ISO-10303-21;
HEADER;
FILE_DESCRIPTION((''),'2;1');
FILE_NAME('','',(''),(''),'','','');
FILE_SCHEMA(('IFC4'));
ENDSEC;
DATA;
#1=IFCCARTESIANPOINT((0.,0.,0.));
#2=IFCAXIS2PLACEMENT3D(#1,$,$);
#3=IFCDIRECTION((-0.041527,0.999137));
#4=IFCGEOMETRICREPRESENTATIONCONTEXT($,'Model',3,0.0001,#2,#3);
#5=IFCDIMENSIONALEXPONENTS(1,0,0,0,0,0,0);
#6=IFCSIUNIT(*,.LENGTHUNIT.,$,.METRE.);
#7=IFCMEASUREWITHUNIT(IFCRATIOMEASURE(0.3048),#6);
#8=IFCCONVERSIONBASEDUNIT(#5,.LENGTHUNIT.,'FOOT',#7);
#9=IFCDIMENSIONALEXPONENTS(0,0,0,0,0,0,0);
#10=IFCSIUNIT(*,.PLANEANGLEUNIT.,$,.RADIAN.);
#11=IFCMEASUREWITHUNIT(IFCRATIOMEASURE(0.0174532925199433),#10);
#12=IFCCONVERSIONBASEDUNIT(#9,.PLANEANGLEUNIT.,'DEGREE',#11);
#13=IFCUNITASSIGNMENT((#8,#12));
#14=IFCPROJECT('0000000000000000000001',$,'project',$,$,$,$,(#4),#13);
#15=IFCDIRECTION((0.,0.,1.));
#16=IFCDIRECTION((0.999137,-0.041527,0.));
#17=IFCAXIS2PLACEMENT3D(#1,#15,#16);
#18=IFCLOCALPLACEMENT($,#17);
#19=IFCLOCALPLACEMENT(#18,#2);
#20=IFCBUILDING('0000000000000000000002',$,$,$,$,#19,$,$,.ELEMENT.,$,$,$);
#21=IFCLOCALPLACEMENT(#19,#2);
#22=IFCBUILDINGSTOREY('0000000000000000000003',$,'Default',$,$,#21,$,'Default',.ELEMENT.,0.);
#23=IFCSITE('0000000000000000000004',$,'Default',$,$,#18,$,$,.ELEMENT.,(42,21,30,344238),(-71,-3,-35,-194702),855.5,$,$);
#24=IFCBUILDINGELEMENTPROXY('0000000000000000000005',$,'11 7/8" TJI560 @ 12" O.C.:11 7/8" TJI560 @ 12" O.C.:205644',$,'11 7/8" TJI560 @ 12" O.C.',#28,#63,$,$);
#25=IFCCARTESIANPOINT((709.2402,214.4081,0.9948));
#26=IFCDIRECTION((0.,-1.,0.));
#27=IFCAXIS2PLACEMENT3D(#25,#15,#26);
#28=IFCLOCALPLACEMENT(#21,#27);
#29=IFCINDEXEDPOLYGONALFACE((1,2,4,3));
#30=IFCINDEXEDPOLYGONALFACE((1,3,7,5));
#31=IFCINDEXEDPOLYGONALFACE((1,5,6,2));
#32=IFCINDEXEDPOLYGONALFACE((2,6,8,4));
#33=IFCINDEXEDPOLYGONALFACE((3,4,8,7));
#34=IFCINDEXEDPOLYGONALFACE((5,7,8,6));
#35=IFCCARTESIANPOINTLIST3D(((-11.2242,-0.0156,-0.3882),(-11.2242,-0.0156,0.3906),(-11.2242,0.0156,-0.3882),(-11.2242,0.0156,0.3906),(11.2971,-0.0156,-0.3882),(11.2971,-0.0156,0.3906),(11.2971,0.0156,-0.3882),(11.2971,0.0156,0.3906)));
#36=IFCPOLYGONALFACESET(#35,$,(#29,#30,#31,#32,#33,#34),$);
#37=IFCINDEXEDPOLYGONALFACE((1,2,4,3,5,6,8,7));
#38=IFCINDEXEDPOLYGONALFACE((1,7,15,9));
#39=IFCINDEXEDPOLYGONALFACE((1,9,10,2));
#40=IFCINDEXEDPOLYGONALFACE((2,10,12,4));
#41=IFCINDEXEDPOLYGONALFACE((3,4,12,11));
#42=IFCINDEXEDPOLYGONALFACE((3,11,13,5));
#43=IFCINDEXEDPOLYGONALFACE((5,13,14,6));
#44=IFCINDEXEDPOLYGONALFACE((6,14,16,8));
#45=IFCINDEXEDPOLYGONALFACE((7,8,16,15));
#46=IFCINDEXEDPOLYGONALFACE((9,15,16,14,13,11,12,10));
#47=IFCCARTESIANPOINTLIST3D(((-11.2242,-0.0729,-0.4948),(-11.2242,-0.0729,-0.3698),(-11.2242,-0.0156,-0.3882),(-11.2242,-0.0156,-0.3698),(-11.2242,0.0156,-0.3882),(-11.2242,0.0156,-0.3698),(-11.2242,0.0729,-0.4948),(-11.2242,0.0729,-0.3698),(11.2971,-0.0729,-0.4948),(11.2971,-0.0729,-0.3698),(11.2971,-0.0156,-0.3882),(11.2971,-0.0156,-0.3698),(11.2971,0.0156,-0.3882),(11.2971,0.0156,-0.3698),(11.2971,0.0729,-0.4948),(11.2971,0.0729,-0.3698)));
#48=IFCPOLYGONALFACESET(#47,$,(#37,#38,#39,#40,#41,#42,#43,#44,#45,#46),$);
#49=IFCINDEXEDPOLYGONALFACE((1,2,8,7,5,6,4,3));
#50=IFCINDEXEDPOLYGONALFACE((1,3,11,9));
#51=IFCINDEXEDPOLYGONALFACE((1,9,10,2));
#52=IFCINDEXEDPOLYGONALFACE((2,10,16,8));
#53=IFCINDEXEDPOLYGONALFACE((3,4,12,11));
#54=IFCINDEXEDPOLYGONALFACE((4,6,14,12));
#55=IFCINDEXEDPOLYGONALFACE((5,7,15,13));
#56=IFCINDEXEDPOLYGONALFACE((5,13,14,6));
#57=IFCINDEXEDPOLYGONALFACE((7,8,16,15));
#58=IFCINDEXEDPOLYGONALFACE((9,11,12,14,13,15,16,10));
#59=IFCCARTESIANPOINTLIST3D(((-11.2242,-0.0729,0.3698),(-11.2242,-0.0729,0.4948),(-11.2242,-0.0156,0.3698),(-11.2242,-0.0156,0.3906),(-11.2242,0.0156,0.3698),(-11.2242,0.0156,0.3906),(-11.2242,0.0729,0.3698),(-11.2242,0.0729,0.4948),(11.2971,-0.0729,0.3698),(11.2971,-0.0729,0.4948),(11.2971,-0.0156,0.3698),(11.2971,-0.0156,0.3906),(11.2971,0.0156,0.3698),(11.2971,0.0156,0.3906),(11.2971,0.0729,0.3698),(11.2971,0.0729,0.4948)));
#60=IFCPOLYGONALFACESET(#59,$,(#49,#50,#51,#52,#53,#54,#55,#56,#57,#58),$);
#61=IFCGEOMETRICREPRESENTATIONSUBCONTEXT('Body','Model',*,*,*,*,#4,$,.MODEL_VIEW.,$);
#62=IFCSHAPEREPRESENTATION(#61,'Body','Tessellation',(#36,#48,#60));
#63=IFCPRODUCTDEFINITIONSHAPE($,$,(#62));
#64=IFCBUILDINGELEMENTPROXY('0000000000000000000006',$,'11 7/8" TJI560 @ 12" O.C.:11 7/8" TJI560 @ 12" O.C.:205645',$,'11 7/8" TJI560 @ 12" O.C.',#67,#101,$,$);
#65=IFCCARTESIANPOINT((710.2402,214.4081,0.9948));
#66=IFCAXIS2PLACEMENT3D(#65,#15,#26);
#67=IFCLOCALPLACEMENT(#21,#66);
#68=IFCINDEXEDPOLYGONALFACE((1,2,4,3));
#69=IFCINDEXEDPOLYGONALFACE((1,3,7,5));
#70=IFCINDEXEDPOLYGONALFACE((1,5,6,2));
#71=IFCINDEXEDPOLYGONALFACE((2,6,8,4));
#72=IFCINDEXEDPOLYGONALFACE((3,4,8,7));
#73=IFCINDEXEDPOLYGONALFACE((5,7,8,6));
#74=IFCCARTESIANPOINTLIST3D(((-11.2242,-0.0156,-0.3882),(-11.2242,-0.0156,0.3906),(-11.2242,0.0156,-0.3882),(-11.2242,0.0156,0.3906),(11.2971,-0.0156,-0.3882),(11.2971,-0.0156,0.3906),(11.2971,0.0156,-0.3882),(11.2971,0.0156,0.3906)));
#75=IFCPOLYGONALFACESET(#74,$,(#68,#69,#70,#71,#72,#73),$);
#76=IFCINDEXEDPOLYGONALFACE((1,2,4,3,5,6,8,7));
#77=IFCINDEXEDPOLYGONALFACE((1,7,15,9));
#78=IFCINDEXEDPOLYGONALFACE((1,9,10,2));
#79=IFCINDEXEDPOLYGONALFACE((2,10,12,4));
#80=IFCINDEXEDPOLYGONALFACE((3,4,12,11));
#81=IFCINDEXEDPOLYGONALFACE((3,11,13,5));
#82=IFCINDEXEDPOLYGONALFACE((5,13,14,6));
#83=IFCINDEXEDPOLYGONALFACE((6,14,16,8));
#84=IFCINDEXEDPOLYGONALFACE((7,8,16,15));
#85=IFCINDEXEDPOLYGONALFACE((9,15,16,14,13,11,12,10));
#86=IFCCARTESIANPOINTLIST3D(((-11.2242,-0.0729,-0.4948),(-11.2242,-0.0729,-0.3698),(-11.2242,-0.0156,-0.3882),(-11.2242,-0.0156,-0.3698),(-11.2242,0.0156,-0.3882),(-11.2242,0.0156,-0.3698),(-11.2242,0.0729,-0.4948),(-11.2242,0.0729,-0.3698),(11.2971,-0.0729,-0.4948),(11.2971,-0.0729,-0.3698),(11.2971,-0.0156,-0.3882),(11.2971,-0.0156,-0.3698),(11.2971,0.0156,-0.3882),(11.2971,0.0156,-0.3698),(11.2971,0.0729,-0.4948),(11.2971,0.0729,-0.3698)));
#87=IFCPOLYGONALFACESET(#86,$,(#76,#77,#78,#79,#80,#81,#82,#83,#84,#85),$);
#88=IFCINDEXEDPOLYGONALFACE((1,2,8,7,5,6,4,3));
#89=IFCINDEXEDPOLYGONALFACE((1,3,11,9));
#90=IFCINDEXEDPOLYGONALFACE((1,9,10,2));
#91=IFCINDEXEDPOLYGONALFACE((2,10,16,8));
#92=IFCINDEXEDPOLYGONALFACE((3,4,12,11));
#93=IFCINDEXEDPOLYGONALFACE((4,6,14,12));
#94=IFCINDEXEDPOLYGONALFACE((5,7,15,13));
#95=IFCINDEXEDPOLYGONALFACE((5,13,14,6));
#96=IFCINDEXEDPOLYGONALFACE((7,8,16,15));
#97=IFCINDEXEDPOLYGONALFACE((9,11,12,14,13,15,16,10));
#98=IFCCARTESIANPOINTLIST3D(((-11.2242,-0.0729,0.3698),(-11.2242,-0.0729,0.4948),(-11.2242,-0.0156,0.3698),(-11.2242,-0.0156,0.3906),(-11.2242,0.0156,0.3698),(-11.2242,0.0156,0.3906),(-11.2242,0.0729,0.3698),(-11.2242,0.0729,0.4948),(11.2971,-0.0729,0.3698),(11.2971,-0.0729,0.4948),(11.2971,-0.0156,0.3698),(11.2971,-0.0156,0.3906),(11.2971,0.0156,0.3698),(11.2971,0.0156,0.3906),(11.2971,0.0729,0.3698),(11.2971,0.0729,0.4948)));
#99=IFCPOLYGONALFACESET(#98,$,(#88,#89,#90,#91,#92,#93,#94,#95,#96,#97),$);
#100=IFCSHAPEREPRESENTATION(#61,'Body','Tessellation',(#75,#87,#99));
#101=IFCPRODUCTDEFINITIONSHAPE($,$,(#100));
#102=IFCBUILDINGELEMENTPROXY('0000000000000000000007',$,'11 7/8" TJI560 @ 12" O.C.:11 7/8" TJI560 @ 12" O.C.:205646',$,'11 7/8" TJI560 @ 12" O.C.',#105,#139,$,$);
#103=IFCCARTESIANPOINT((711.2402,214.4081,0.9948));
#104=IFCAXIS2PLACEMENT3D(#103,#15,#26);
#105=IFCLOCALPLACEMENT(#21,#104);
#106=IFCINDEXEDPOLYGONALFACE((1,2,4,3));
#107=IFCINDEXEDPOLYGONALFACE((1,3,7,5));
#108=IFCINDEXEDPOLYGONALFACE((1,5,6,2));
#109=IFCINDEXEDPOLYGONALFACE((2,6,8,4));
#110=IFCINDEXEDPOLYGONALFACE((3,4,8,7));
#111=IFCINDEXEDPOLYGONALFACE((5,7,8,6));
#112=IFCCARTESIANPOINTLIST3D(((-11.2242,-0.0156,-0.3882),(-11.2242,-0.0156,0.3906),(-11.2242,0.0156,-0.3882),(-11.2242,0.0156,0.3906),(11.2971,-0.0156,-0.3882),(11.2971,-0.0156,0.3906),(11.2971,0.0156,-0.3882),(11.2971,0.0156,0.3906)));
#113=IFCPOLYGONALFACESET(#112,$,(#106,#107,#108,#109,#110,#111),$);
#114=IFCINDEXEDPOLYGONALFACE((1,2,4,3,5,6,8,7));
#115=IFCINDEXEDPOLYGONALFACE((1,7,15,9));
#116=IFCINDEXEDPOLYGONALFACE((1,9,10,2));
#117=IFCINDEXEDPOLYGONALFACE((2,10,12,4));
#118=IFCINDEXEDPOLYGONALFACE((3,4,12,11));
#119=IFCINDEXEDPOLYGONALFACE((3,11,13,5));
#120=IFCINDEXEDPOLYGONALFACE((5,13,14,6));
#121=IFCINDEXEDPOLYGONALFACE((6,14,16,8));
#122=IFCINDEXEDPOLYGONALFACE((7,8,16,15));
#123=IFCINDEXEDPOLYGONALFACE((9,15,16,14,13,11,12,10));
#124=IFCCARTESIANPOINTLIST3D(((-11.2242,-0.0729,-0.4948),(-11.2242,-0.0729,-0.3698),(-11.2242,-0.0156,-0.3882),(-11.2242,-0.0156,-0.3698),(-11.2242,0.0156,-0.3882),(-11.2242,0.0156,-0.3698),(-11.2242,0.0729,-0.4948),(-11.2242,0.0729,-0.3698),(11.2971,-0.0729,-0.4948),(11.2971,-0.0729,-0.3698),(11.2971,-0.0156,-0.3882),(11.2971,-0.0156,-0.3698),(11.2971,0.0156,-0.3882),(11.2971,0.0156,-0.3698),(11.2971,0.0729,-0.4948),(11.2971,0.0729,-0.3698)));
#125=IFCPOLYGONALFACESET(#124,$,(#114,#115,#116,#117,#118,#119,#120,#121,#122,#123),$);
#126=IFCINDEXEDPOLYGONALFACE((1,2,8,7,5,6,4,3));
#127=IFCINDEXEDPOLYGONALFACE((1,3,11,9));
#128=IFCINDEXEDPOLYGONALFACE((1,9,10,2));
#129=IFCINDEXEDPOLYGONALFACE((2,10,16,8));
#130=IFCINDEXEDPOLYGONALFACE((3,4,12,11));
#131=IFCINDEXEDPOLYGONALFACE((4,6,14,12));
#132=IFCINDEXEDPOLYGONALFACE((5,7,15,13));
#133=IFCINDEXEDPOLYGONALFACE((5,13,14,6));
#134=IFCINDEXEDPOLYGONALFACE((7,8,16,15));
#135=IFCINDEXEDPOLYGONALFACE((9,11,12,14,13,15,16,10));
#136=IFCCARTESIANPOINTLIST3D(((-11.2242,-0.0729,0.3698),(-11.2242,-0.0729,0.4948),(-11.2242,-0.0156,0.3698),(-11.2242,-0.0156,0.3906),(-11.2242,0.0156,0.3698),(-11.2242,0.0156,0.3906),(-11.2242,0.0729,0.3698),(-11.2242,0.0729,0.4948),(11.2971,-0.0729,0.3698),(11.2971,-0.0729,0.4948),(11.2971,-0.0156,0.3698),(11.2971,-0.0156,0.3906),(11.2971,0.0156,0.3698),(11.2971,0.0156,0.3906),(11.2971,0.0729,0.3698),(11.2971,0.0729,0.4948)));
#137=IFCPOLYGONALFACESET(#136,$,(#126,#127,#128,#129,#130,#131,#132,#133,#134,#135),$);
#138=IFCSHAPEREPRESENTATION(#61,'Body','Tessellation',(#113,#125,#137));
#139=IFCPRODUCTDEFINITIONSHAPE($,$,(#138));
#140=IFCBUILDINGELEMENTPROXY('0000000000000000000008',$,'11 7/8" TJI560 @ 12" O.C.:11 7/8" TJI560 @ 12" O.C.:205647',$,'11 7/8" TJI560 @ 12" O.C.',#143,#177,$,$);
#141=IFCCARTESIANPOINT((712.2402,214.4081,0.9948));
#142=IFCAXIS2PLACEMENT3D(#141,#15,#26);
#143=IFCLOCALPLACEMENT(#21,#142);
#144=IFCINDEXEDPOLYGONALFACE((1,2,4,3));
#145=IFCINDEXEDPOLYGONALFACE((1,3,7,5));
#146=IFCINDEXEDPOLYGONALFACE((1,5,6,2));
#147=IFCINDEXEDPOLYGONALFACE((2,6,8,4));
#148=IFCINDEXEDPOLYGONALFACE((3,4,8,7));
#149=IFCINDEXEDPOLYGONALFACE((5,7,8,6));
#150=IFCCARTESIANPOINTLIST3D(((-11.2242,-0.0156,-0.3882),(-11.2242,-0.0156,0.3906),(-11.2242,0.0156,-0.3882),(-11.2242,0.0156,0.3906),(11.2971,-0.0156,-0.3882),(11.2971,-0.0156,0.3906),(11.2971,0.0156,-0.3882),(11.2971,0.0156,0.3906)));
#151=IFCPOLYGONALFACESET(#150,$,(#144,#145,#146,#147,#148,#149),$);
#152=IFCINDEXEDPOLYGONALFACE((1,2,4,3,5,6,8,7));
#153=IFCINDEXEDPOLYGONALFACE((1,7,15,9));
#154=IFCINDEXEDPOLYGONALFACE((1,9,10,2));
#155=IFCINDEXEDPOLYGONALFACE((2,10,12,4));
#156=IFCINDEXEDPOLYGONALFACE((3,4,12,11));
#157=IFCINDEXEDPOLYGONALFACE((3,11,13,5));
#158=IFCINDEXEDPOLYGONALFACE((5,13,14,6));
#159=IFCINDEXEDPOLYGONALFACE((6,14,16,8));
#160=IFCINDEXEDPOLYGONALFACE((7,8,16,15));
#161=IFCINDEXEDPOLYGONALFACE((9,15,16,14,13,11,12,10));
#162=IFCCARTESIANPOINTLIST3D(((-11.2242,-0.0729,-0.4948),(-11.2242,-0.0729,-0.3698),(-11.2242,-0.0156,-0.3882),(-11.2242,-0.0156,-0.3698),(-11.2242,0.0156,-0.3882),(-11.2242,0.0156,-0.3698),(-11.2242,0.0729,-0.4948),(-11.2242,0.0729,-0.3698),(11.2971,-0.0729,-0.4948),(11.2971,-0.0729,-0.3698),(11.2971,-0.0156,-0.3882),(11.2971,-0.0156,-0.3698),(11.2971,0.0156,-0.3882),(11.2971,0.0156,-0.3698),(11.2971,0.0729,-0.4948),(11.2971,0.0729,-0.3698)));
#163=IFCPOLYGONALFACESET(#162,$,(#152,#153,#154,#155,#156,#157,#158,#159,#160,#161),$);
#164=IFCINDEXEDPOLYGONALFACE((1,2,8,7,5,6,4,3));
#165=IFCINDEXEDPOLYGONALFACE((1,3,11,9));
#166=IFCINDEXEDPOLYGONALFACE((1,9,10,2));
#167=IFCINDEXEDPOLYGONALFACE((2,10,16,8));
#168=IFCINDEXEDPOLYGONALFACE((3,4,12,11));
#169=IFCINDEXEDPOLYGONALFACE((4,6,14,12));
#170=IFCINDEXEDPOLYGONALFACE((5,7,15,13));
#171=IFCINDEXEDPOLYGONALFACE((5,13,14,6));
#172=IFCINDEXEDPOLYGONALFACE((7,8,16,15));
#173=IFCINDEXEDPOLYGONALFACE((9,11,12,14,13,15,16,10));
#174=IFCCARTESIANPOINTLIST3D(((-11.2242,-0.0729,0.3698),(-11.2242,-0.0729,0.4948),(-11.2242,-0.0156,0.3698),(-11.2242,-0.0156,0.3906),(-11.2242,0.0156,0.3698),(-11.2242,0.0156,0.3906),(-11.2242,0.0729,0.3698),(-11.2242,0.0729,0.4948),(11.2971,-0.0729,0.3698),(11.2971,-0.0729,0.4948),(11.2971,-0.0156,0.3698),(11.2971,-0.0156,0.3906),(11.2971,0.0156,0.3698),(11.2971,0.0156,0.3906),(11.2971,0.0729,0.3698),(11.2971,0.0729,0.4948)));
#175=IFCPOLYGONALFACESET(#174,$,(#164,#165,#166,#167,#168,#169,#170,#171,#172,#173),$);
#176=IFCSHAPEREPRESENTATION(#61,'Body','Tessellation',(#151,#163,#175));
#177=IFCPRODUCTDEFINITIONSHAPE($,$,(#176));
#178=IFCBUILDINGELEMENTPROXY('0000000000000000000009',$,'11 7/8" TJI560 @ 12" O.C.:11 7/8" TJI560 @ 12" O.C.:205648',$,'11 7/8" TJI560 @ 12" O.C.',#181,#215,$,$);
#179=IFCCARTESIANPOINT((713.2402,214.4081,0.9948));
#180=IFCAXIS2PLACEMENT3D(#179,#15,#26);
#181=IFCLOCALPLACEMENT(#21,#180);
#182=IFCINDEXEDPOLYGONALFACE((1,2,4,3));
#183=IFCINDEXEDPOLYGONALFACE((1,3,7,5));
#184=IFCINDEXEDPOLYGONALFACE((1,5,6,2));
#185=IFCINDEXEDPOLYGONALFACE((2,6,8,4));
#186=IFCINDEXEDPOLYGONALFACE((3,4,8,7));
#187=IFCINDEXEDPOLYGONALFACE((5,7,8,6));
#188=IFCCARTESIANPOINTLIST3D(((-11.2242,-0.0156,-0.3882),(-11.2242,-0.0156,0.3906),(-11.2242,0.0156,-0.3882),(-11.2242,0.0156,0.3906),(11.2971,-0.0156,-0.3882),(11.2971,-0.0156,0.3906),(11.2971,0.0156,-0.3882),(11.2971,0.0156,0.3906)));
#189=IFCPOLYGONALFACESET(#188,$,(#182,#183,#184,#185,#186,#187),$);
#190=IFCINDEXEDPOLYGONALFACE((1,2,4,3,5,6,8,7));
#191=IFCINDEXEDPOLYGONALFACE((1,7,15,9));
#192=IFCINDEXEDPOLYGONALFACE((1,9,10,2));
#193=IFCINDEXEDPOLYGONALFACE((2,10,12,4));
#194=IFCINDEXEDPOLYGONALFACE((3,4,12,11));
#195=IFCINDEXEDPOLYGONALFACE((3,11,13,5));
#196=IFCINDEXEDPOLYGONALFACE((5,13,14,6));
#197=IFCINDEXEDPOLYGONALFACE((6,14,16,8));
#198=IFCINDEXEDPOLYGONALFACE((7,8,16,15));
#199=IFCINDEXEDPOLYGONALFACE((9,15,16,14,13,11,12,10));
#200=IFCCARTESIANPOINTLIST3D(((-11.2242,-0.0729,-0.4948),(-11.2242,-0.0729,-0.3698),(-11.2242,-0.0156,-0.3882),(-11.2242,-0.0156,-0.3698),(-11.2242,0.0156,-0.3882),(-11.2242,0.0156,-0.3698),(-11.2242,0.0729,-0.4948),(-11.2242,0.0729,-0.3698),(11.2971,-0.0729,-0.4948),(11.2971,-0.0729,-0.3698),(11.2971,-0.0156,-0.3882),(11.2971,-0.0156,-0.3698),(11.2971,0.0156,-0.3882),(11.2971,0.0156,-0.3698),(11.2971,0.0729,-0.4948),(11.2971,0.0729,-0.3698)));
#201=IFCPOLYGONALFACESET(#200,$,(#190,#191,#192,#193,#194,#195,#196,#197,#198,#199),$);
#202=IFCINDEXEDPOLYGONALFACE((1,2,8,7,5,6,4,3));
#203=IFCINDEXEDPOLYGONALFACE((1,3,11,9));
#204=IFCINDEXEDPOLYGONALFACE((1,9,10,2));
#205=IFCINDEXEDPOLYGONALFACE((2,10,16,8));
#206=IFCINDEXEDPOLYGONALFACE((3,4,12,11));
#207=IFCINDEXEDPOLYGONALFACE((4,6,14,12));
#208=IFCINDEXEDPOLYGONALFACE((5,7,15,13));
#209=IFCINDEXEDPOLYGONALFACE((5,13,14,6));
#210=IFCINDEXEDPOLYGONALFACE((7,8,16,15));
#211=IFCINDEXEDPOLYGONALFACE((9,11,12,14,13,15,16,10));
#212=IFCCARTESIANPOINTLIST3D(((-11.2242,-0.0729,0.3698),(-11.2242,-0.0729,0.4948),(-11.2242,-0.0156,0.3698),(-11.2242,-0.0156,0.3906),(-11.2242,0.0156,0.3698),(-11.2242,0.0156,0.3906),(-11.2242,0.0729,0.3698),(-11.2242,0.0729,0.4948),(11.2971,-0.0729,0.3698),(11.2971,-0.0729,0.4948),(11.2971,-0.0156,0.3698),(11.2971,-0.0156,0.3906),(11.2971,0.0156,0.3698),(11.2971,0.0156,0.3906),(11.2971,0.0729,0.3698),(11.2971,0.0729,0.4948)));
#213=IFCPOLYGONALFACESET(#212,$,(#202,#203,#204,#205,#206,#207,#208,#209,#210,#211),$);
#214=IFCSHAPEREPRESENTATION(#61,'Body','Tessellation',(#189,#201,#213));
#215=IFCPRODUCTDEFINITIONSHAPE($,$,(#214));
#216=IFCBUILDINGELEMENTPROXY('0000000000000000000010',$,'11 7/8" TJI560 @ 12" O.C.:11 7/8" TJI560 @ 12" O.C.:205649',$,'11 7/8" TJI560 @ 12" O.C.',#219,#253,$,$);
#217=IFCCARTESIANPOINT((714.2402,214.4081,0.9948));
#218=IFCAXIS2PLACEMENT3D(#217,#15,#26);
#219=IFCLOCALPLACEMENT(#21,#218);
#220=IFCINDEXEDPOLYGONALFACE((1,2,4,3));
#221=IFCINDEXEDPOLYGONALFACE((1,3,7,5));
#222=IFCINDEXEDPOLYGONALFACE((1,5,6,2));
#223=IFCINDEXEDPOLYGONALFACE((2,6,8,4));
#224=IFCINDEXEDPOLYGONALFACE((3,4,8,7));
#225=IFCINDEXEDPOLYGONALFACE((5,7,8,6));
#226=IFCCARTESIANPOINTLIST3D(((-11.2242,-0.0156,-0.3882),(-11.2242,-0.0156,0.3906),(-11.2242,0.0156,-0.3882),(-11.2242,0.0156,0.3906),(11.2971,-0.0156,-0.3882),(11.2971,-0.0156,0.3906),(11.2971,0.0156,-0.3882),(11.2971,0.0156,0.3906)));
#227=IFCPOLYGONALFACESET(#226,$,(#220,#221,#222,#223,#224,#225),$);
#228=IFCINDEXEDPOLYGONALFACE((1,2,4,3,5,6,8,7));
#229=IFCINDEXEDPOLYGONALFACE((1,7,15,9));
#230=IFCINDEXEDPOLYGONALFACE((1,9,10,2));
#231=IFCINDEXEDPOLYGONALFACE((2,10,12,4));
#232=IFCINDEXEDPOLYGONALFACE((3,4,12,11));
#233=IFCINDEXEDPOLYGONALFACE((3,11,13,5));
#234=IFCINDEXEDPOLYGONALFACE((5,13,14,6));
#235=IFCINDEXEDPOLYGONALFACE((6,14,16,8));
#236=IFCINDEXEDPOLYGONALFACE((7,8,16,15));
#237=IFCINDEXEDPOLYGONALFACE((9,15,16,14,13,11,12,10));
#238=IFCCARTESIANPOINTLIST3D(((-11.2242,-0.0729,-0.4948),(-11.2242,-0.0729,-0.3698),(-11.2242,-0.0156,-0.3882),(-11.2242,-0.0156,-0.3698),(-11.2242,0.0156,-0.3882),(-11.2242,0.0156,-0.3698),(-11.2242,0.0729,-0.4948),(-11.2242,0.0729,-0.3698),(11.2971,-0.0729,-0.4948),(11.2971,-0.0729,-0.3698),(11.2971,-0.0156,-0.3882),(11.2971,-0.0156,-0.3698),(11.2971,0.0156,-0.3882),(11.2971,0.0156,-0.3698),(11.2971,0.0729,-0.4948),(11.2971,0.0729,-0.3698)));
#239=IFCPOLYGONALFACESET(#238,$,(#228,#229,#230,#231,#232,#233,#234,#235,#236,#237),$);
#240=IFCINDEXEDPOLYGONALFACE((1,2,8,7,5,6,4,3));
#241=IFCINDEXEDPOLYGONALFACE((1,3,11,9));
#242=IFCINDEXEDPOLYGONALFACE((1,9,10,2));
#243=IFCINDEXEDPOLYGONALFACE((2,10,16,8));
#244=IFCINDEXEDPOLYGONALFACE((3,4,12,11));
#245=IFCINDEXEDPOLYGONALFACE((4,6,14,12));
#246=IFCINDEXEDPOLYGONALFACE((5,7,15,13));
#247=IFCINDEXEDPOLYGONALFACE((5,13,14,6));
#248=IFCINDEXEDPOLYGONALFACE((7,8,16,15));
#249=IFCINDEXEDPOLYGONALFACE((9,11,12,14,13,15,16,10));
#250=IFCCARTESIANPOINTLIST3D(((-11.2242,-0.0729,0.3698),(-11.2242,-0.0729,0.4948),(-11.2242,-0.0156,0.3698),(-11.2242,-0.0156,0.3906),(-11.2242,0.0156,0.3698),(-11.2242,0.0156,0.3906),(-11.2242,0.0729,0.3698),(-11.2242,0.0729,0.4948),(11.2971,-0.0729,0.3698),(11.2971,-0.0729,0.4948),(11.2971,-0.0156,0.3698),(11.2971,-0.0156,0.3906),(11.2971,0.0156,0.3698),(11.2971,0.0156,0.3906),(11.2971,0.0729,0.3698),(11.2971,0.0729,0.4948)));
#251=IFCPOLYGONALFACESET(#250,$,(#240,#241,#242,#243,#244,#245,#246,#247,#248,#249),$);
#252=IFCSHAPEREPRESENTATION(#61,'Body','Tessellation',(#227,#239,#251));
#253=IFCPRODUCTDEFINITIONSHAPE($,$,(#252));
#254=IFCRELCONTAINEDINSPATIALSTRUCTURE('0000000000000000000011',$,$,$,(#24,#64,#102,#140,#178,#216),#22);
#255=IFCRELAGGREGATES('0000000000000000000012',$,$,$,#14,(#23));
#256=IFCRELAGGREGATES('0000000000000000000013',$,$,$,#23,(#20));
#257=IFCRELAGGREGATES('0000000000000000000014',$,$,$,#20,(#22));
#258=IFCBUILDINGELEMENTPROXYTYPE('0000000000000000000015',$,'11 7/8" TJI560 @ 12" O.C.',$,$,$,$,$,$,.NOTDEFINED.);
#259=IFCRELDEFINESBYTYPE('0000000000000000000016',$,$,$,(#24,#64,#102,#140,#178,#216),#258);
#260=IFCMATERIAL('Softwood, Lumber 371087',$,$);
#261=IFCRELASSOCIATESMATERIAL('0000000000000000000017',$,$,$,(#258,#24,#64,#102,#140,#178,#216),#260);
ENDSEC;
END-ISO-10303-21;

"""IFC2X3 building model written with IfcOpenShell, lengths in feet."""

from ifc_helpers import new_model, entity, si_unit, converted_unit, direction, frame, origin, origin_2d_with_axis, place, context, subcontext, project, spatial, polyline, rectangle, outline, extrude, source, transform, mapped, material, type_object, type_shapes, element, save


model = new_model("IFC2X3")

# Units and contexts
model_context = context("Model", 3, precision=0.0001, world=origin(), true_north=direction((-0.041527, 0.999137)))
body_context = subcontext(model_context, "Body", "Model", "MODEL_VIEW")
ifc_project = project(units=[converted_unit("LENGTHUNIT", "FOOT", entity("IfcRatioMeasure", 0.3048), si_unit("LENGTHUNIT", "METRE"), dimensions=[1, 0, 0, 0, 0, 0, 0]), converted_unit("PLANEANGLEUNIT", "DEGREE", entity("IfcRatioMeasure", 0.0174532925199433), si_unit("PLANEANGLEUNIT", "RADIAN"), dimensions=[0, 0, 0, 0, 0, 0, 0])], contexts=[model_context])

# Site, building, storey
site_placement = place(None, frame((0.0, 0.0, 0.0), z_axis=(0.0, 0.0, 1.0), x_axis=(0.999137, -0.041527, 0.0)))
site = spatial("IfcSite", under=ifc_project, at=site_placement, Name="Default", CompositionType="ELEMENT", RefLatitude=(42, 21, 30, 344238), RefLongitude=(-71, -3, -35, -194702), RefElevation=855.5)
building_placement = place(site_placement, origin())
building = spatial("IfcBuilding", under=site, at=building_placement, CompositionType="ELEMENT")
storey_placement = place(building_placement, origin())
storey = spatial("IfcBuildingStorey", under=building, at=storey_placement, Name="Default", LongName="Default", CompositionType="ELEMENT", Elevation=0.0)

# Building element proxies
ifc_material = material(Name="Softwood, Lumber 371087")
building_element_proxy_type_1 = type_object("IfcBuildingElementProxyType", Name="11 7/8\" TJI560 @ 12\" O.C.", PredefinedType="NOTDEFINED", material=ifc_material)
shared_shape_1 = source(origin(), body_context, "Body", "SweptSolid", [
    extrude(rectangle(XDim=22.5212, YDim=0.0313, at=origin_2d_with_axis()), frame((0.0365, 0.0, -0.3882), z_axis=(0.0, 0.0, 1.0), x_axis=(-1.0, 0.0, 0.0)), (0.0, 0.0, 1.0), 0.7788),
    extrude(outline(polyline([(-0.0891, -0.0729), (0.0359, -0.0729), (0.0359, -0.0156), (0.0174, -0.0156), (0.0174, 0.0156), (0.0359, 0.0156), (0.0359, 0.0729), (-0.0891, 0.0729), (-0.0891, -0.0729)])), frame((-11.2242, 0.0, -0.4056), z_axis=(1.0, 0.0, 0.0), x_axis=(0.0, 0.0, 1.0)), (0.0, 0.0, 1.0), 22.5212),
    extrude(outline(polyline([(-0.0729, -0.0885), (0.0729, -0.0885), (0.0729, 0.0365), (0.0156, 0.0365), (0.0156, 0.0156), (-0.0156, 0.0156), (-0.0156, 0.0365), (-0.0729, 0.0365), (-0.0729, -0.0885)])), frame((-11.2242, 0.0, 0.4062), z_axis=(1.0, 0.0, 0.0), x_axis=(0.0, -1.0, 0.0)), (0.0, 0.0, 1.0), 22.5212),
])
type_shapes(building_element_proxy_type_1, [shared_shape_1])
for number, where, z_axis, x_axis, name in (
    (1, (709.2402, 214.4081, 0.9948), (0.0, 0.0, 1.0), (0.0, -1.0, 0.0), "11 7/8\" TJI560 @ 12\" O.C.:11 7/8\" TJI560 @ 12\" O.C.:205644"),
    (2, (710.2402, 214.4081, 0.9948), (0.0, 0.0, 1.0), (0.0, -1.0, 0.0), "11 7/8\" TJI560 @ 12\" O.C.:11 7/8\" TJI560 @ 12\" O.C.:205645"),
    (3, (711.2402, 214.4081, 0.9948), (0.0, 0.0, 1.0), (0.0, -1.0, 0.0), "11 7/8\" TJI560 @ 12\" O.C.:11 7/8\" TJI560 @ 12\" O.C.:205646"),
    (4, (712.2402, 214.4081, 0.9948), (0.0, 0.0, 1.0), (0.0, -1.0, 0.0), "11 7/8\" TJI560 @ 12\" O.C.:11 7/8\" TJI560 @ 12\" O.C.:205647"),
    (5, (713.2402, 214.4081, 0.9948), (0.0, 0.0, 1.0), (0.0, -1.0, 0.0), "11 7/8\" TJI560 @ 12\" O.C.:11 7/8\" TJI560 @ 12\" O.C.:205648"),
    (6, (714.2402, 214.4081, 0.9948), (0.0, 0.0, 1.0), (0.0, -1.0, 0.0), "11 7/8\" TJI560 @ 12\" O.C.:11 7/8\" TJI560 @ 12\" O.C.:205649"),
):
    element("IfcBuildingElementProxy", number, at=place(storey_placement, frame(where, z_axis=z_axis, x_axis=x_axis)), inside=storey, type_object=building_element_proxy_type_1, material=ifc_material, Name=name, ObjectType="11 7/8\" TJI560 @ 12\" O.C.", context=body_context, shape_type="MappedRepresentation", body=[
        mapped(shared_shape_1, transform((0.0, 0.0, 0.0), scale=1.0)),
    ])

save(model, "model.ifc")
